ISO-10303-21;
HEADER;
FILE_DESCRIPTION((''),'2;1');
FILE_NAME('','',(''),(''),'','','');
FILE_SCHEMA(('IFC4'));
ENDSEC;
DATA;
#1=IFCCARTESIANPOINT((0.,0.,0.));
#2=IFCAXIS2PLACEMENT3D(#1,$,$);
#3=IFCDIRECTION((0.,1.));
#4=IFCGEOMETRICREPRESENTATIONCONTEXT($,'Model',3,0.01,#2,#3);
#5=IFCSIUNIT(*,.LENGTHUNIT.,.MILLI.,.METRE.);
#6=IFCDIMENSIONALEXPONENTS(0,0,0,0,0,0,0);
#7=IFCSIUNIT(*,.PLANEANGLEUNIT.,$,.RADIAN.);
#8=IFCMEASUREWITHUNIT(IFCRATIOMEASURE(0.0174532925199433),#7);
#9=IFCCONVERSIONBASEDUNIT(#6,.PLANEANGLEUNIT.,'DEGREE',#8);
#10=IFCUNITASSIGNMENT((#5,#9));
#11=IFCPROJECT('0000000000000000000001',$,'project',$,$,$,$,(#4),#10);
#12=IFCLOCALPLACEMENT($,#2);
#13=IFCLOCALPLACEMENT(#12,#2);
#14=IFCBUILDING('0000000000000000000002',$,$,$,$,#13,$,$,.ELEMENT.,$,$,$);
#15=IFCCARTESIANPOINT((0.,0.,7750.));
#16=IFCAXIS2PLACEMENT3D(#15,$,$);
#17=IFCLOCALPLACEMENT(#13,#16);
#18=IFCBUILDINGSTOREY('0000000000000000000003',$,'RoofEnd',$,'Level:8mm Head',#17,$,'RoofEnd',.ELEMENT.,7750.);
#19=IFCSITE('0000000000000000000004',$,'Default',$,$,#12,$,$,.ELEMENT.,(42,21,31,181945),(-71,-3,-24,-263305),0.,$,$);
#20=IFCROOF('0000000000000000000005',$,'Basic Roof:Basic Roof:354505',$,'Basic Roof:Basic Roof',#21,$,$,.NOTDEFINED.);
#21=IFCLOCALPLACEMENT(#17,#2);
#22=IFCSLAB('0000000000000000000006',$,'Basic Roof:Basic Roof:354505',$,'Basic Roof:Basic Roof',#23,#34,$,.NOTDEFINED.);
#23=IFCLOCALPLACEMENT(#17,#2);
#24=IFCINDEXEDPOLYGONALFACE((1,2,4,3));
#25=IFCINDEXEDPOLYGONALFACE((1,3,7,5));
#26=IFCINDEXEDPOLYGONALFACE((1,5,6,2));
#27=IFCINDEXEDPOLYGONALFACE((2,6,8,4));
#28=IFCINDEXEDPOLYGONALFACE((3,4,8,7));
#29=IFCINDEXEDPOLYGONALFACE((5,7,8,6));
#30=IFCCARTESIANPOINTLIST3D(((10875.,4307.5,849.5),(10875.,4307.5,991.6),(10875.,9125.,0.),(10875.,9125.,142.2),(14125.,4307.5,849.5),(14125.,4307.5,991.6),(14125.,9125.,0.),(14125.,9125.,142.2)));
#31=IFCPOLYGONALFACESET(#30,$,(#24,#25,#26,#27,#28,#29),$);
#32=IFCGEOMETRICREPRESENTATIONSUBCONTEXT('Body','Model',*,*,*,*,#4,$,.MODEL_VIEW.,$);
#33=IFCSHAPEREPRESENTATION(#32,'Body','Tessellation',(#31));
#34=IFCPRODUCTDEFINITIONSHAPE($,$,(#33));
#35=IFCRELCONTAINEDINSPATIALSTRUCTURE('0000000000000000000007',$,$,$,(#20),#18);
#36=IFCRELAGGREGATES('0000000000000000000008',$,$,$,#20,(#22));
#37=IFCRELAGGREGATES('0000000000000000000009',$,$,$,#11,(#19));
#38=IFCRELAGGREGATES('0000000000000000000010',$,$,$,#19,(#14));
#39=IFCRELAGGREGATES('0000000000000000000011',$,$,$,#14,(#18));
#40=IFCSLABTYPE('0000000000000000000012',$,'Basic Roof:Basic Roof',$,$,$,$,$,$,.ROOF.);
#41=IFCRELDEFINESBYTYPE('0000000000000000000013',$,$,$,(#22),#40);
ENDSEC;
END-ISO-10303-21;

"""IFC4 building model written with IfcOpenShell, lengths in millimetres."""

from ifc_helpers import new_model, entity, si_unit, converted_unit, direction, frame, frame_2d, origin, place, context, subcontext, project, spatial, rectangle, extrude, type_object, element, aggregate, save


model = new_model("IFC4")

# Units and contexts
model_context = context("Model", 3, precision=0.01, world=origin(), true_north=direction((0.0, 1.0)))
body_context = subcontext(model_context, "Body", "Model", "MODEL_VIEW")
ifc_project = project(units=[si_unit("LENGTHUNIT", "METRE", prefix="MILLI"), converted_unit("PLANEANGLEUNIT", "DEGREE", entity("IfcRatioMeasure", 0.0174532925199433), si_unit("PLANEANGLEUNIT", "RADIAN"), dimensions=[0, 0, 0, 0, 0, 0, 0])], contexts=[model_context])

# Site, building, storey
site_placement = place(None, origin())
site = spatial("IfcSite", under=ifc_project, at=site_placement, Name="Default", CompositionType="ELEMENT", RefLatitude=(42, 21, 31, 181945), RefLongitude=(-71, -3, -24, -263305), RefElevation=0.0)
building_placement = place(site_placement, origin())
building = spatial("IfcBuilding", under=site, at=building_placement, CompositionType="ELEMENT")
storey_placement = place(building_placement, frame((0.0, 0.0, 7750.0)))
storey = spatial("IfcBuildingStorey", under=building, at=storey_placement, Name="RoofEnd", ObjectType="Level:8mm Head", LongName="RoofEnd", CompositionType="ELEMENT", Elevation=7750.0)

# Roof, slab
roof_placement = place(storey_placement, frame((10875.0, 4307.5, 0.0)))
roof = element("IfcRoof", 1, at=roof_placement, inside=storey, Name="Basic Roof:Basic Roof:354505", ObjectType="Basic Roof:Basic Roof", PredefinedType="NOTDEFINED")
slab_type = type_object("IfcSlabType", Name="Basic Roof:Basic Roof", PredefinedType="ROOF")
slab_placement = place(roof_placement, origin())
slab = element("IfcSlab", 2, at=slab_placement, type_object=slab_type, Name="Basic Roof:Basic Roof:354505", ObjectType="Basic Roof:Basic Roof", PredefinedType="NOTDEFINED", context=body_context, shape_type="SweptSolid", body=[
    extrude(rectangle(XDim=3250.0, YDim=4891.8, at=frame_2d((0.0, 0.0), x_axis=(1.0, 0.0))), frame((1625.0, 2408.7, 424.7), z_axis=(0.0, 0.173648, 0.984808), x_axis=(1.0, 0.0, 0.0)), (0.0, -0.173648, 0.984808), 142.2),
])
aggregate(roof, [slab])

save(model, "model.ifc")
